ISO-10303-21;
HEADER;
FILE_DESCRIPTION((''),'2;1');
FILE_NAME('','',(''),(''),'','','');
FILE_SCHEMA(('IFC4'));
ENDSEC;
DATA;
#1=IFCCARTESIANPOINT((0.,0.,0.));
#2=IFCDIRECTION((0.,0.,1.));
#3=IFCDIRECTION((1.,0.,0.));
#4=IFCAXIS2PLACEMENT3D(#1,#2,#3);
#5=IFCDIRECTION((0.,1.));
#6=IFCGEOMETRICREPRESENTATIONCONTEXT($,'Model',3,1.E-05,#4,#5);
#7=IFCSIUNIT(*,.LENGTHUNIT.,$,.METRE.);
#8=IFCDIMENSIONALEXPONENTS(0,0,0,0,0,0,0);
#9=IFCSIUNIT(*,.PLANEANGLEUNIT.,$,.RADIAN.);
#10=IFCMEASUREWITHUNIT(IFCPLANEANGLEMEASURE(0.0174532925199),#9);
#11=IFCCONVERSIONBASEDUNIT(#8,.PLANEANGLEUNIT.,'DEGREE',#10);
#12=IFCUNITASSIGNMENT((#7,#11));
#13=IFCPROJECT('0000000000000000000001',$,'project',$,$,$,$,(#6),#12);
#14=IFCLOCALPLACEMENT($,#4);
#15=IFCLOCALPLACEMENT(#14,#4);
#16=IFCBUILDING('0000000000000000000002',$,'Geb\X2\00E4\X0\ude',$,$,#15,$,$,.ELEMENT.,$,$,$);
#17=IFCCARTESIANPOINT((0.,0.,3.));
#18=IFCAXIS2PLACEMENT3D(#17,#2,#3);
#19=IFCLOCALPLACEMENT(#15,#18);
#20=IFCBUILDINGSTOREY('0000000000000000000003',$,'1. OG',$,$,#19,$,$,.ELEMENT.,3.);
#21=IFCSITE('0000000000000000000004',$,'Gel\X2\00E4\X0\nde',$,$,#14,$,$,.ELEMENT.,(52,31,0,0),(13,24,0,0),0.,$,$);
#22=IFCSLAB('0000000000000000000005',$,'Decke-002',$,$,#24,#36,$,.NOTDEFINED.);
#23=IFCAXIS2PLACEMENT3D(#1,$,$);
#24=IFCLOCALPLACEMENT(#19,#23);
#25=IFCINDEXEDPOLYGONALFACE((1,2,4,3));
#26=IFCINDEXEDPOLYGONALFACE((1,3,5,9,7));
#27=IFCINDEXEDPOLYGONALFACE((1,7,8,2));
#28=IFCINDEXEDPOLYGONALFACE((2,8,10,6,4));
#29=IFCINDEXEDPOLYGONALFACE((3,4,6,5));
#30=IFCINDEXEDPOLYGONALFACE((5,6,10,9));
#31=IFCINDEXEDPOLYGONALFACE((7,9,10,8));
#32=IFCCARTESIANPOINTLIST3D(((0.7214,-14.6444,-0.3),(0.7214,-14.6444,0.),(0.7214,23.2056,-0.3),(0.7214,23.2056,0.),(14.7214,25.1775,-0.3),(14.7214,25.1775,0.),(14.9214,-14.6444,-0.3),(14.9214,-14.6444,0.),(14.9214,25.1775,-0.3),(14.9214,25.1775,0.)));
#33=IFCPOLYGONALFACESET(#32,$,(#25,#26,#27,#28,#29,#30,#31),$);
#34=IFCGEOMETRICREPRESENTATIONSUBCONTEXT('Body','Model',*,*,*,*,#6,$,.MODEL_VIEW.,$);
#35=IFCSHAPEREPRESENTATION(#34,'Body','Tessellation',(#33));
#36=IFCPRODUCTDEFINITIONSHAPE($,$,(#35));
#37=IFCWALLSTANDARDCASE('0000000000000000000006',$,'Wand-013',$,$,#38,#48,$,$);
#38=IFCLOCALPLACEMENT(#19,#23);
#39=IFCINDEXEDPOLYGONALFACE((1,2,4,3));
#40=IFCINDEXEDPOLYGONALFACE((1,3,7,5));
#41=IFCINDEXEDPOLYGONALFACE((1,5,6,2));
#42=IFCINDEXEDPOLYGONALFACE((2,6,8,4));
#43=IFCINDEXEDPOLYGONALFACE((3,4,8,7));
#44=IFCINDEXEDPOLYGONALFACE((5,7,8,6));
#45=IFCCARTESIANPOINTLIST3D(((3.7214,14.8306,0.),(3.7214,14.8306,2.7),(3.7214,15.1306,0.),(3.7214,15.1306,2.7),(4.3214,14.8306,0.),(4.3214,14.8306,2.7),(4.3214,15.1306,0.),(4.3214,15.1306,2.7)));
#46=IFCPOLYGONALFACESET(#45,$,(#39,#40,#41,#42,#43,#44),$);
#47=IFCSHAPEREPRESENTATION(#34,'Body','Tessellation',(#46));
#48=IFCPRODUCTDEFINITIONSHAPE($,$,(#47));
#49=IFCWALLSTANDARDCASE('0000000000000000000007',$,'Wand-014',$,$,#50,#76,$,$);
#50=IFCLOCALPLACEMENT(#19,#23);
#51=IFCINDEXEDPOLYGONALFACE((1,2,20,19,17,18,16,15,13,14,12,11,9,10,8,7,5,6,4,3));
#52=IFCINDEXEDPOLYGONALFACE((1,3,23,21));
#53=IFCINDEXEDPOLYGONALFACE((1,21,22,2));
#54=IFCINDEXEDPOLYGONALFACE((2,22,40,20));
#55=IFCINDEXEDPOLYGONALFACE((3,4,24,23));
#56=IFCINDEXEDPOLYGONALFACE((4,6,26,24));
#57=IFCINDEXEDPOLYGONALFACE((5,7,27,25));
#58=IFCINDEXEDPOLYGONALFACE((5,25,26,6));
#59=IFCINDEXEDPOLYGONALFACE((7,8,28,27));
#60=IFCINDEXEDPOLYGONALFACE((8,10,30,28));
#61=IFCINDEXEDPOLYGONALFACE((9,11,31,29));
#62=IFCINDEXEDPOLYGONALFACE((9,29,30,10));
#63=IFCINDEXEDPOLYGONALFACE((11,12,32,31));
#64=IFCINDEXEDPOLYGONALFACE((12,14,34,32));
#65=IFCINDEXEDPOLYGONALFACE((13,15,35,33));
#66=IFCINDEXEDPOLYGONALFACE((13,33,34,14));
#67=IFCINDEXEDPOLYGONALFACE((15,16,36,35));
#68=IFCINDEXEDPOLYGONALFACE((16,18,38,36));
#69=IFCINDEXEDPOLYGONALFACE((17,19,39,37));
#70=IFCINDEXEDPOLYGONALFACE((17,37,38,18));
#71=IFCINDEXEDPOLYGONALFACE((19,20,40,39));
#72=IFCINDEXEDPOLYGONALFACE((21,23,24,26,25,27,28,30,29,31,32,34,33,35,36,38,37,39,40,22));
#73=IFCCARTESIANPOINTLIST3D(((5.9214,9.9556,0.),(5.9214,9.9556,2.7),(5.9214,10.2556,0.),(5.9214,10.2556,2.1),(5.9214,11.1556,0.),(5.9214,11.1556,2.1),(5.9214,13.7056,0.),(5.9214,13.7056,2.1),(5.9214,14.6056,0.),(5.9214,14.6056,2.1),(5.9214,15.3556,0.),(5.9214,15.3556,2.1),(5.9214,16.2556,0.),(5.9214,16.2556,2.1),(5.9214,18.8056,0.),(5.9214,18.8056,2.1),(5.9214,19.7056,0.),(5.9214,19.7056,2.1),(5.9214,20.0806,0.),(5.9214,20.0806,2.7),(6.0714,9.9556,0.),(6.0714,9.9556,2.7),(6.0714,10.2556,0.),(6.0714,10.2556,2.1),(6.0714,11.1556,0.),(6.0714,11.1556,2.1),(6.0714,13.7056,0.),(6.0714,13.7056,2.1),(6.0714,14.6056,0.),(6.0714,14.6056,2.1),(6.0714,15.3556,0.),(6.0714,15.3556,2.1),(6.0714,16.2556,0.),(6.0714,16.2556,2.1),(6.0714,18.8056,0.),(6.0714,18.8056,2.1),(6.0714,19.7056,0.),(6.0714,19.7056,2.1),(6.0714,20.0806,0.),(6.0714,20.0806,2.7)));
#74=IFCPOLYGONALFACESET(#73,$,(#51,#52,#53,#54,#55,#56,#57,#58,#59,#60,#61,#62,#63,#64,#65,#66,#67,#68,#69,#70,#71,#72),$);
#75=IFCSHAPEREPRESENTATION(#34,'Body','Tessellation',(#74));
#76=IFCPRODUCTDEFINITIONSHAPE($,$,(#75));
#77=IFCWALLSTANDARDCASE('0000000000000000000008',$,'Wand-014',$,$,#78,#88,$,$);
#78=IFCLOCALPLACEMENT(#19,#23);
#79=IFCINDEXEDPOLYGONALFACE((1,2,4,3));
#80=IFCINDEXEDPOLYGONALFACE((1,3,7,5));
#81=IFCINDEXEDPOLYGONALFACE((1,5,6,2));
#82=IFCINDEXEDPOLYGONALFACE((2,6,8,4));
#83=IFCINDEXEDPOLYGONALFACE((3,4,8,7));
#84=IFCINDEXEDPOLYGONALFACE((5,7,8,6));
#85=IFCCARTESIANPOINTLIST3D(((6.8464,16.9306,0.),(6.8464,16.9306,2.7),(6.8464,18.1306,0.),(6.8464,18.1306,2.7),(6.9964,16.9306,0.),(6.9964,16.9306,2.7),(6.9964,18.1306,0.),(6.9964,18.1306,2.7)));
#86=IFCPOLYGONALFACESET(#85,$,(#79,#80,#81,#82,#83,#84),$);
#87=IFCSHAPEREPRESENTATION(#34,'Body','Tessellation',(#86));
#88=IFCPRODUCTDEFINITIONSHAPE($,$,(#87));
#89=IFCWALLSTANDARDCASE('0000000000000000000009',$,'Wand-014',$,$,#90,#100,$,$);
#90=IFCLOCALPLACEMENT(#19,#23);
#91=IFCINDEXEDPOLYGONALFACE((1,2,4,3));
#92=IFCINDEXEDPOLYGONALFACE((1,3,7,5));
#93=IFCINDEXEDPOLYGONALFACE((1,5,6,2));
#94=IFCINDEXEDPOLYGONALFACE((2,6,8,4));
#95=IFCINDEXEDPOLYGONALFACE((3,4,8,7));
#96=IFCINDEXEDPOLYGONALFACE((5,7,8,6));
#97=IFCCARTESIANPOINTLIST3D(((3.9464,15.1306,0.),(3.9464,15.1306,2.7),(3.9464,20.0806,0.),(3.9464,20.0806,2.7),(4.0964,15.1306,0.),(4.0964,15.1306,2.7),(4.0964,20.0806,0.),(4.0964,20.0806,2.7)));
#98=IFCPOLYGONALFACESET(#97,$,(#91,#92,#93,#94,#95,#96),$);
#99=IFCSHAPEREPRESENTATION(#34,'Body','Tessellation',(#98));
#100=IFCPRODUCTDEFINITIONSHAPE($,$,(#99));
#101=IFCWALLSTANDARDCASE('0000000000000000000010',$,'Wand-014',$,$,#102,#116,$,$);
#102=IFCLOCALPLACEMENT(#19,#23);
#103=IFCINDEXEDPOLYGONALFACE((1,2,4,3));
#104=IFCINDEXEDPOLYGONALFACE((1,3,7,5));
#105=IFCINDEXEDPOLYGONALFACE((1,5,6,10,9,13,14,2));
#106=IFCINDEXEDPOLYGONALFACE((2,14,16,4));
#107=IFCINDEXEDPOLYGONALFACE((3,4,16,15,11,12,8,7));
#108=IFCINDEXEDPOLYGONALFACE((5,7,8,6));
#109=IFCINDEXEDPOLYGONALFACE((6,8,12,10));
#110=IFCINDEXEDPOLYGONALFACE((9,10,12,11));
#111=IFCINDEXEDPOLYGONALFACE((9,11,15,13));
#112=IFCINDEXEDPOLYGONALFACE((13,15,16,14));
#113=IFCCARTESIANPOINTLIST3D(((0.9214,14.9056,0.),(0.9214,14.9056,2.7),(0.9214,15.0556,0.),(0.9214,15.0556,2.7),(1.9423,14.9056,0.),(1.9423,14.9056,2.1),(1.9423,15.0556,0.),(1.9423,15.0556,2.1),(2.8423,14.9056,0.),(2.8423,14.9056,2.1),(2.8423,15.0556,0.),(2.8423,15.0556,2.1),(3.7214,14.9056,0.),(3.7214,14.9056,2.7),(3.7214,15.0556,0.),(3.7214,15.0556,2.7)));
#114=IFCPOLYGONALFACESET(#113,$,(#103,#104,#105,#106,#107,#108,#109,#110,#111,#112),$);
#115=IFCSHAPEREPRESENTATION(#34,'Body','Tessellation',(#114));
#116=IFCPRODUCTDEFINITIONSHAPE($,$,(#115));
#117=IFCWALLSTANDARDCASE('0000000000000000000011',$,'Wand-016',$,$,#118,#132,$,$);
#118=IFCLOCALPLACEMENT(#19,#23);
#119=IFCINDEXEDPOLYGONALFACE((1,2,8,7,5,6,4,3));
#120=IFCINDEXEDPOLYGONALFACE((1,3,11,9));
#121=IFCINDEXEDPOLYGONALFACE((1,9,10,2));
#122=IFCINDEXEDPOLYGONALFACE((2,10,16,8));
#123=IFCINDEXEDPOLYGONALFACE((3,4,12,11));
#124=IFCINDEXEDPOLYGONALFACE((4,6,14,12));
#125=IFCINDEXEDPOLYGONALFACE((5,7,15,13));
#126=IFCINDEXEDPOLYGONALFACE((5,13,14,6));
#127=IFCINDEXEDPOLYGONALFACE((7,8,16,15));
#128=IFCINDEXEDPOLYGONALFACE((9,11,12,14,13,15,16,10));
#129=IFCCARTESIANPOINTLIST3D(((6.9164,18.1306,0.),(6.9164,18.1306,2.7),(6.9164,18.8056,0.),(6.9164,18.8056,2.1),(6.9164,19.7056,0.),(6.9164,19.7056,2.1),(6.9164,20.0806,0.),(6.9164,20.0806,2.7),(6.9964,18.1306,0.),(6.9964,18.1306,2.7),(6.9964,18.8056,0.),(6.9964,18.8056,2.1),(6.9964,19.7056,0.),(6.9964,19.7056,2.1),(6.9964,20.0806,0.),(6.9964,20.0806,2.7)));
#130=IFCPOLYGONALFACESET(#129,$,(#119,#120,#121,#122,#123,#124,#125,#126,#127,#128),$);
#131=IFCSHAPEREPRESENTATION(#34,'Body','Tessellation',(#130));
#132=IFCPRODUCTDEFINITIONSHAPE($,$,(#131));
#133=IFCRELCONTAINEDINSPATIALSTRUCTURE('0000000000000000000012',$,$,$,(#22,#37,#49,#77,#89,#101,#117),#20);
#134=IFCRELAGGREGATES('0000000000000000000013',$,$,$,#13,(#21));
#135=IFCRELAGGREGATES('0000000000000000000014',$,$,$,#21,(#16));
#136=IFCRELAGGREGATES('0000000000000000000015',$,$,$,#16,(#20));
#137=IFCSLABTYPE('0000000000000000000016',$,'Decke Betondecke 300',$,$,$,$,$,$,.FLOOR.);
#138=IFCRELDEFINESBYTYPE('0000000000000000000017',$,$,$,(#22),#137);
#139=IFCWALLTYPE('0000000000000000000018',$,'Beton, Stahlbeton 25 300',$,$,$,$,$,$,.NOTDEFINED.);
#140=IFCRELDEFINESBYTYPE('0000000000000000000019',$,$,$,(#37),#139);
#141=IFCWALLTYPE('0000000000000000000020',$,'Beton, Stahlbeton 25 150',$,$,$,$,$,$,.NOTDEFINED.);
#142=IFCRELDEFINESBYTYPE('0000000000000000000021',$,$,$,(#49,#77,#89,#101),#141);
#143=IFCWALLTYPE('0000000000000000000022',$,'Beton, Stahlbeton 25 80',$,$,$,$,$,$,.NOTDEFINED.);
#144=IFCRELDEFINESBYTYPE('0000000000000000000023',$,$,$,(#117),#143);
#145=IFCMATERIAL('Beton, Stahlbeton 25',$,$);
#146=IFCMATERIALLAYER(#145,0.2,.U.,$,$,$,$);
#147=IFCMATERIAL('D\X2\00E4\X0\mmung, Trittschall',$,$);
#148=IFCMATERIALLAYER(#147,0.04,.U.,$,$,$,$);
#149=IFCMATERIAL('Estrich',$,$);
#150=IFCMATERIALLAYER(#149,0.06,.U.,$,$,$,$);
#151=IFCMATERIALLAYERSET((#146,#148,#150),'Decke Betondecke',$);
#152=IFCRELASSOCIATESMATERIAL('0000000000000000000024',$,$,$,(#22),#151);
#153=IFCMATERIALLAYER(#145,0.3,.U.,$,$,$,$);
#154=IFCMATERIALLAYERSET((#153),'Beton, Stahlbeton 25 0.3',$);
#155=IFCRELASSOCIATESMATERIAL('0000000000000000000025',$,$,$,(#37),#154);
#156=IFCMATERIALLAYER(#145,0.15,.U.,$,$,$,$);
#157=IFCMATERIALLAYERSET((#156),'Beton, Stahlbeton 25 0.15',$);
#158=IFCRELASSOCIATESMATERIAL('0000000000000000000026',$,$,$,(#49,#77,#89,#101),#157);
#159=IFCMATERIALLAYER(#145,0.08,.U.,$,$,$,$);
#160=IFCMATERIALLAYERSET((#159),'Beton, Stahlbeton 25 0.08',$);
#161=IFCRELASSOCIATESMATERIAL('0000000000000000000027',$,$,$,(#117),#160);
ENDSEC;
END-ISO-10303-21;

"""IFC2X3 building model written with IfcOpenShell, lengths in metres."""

from ifc_helpers import new_model, entity, si_unit, converted_unit, direction, frame, origin_with_axes, origin_2d_with_axis, place, context, subcontext, project, spatial, polyline, rectangle, outline, extrude, material, layer, layer_set, layer_usage, type_object, element, save


model = new_model("IFC2X3")

# Units and contexts
model_context = context("Model", 3, precision=1e-05, world=origin_with_axes(), true_north=direction((0.0, 1.0)))
body_context = subcontext(model_context, "Body", "Model", "MODEL_VIEW")
ifc_project = project(units=[si_unit("LENGTHUNIT", "METRE"), converted_unit("PLANEANGLEUNIT", "DEGREE", entity("IfcPlaneAngleMeasure", 0.0174532925199), si_unit("PLANEANGLEUNIT", "RADIAN"), dimensions=[0, 0, 0, 0, 0, 0, 0])], contexts=[model_context])

# Site, building, storey
site_placement = place(None, origin_with_axes())
site = spatial("IfcSite", under=ifc_project, at=site_placement, Name="Gelände", CompositionType="ELEMENT", RefLatitude=(52, 31, 0, 0), RefLongitude=(13, 24, 0, 0), RefElevation=0.0)
building_placement = place(site_placement, origin_with_axes())
building = spatial("IfcBuilding", under=site, at=building_placement, Name="Gebäude", CompositionType="ELEMENT")
storey_placement = place(building_placement, frame((0.0, 0.0, 3.0), z_axis=(0.0, 0.0, 1.0), x_axis=(1.0, 0.0, 0.0)))
storey = spatial("IfcBuildingStorey", under=building, at=storey_placement, Name="1. OG", CompositionType="ELEMENT", Elevation=3.0)

# Slab
ifc_material_1 = material(Name="Beton, Stahlbeton 25")
ifc_layer_1 = layer(ifc_material_1, 0.2, ventilated="UNKNOWN")
ifc_material_2 = material(Name="Dämmung, Trittschall")
ifc_layer_2 = layer(ifc_material_2, 0.04, ventilated="UNKNOWN")
ifc_material_3 = material(Name="Estrich")
ifc_layer_3 = layer(ifc_material_3, 0.06, ventilated="UNKNOWN")
ifc_layer_set_1 = layer_set([ifc_layer_1, ifc_layer_2, ifc_layer_3], Name="Decke Betondecke")
ifc_layer_usage_1 = layer_usage(ifc_layer_set_1, "AXIS3", "NEGATIVE", 0.3)
slab_type = type_object("IfcSlabType", Name="Decke Betondecke 300", PredefinedType="FLOOR")
slab_placement = place(storey_placement, frame((0.7214, 23.2056, 0.0), z_axis=(0.0, 0.0, 1.0), x_axis=(1.0, 0.0, 0.0)))
element("IfcSlab", 1, at=slab_placement, inside=storey, type_object=slab_type, material=ifc_layer_usage_1, Name="Decke-002", PredefinedType="NOTDEFINED", context=body_context, shape_type="SweptSolid", body=[
    extrude(outline(polyline([(0.0, 0.0), (0.0, -37.85), (14.2, -37.85), (14.2, 1.9718), (14.0, 1.9718), (0.0, 0.0)])), frame((0.0, 0.0, -0.3), z_axis=(0.0, 0.0, 1.0), x_axis=(1.0, 0.0, 0.0)), (0.0, 0.0, 1.0), 0.3),
])

# Wall
ifc_layer_4 = layer(ifc_material_1, 0.3, ventilated="UNKNOWN")
ifc_layer_set_2 = layer_set([ifc_layer_4], Name="Beton, Stahlbeton 25 0.3")
ifc_layer_usage_2 = layer_usage(ifc_layer_set_2, "AXIS2", "NEGATIVE", 0.3)
wall_type_1 = type_object("IfcWallType", Name="Beton, Stahlbeton 25 300", PredefinedType="NOTDEFINED")
wall_1_placement = place(storey_placement, frame((3.7214, 14.8306, 0.0), z_axis=(0.0, 0.0, 1.0), x_axis=(1.0, 0.0, 0.0)))
element("IfcWallStandardCase", 2, at=wall_1_placement, inside=storey, type_object=wall_type_1, material=ifc_layer_usage_2, Name="Wand-013", context=body_context, shape_type="SweptSolid", body=[
    extrude(outline(polyline([(0.0, 0.0), (0.6, 0.0), (0.6, 0.3), (0.0, 0.3), (0.0, 0.0)])), origin_with_axes(), (0.0, 0.0, 1.0), 2.7),
])

# Wall, openings
ifc_layer_5 = layer(ifc_material_1, 0.15, ventilated="UNKNOWN")
ifc_layer_set_3 = layer_set([ifc_layer_5], Name="Beton, Stahlbeton 25 0.15")
ifc_layer_usage_3 = layer_usage(ifc_layer_set_3, "AXIS2", "POSITIVE", 0.0)
wall_type_2 = type_object("IfcWallType", Name="Beton, Stahlbeton 25 150", PredefinedType="NOTDEFINED")
wall_2_placement = place(storey_placement, frame((5.9214, 20.0806, 0.0), z_axis=(0.0, 0.0, 1.0), x_axis=(0.0, -1.0, 0.0)))
wall_2 = element("IfcWallStandardCase", 3, at=wall_2_placement, inside=storey, type_object=wall_type_2, material=ifc_layer_usage_3, Name="Wand-014", context=body_context, shape_type="SweptSolid", body=[
    extrude(outline(polyline([(0.0, 0.0), (10.125, 0.0), (10.125, 0.15), (0.0, 0.15), (0.0, 0.0)])), origin_with_axes(), (0.0, 0.0, 1.0), 2.7),
])
opening_1_placement = place(wall_2_placement, frame((4.275, 0.0, 0.0), z_axis=(0.0, 0.0, 1.0), x_axis=(1.0, 0.0, 0.0)))
element("IfcOpeningElement", 4, at=opening_1_placement, cuts=wall_2, context=body_context, shape_type="SweptSolid", body=[
    extrude(rectangle(XDim=0.9, YDim=2.1, at=origin_2d_with_axis()), frame((0.0, 0.3, 1.05), z_axis=(0.0, -1.0, 0.0), x_axis=(1.0, 0.0, 0.0)), (0.0, 0.0, 1.0), 0.15),
    extrude(rectangle(XDim=0.9, YDim=2.1, at=origin_2d_with_axis()), frame((0.0, 0.0, 1.05), z_axis=(0.0, 1.0, 0.0), x_axis=(1.0, 0.0, 0.0)), (0.0, 0.0, 1.0), 0.15),
])
opening_2_placement = place(wall_2_placement, frame((5.925, 0.0, 0.0), z_axis=(0.0, 0.0, 1.0), x_axis=(1.0, 0.0, 0.0)))
element("IfcOpeningElement", 5, at=opening_2_placement, cuts=wall_2, context=body_context, shape_type="SweptSolid", body=[
    extrude(rectangle(XDim=0.9, YDim=2.1, at=origin_2d_with_axis()), frame((0.0, 0.3, 1.05), z_axis=(0.0, -1.0, 0.0), x_axis=(1.0, 0.0, 0.0)), (0.0, 0.0, 1.0), 0.15),
    extrude(rectangle(XDim=0.9, YDim=2.1, at=origin_2d_with_axis()), frame((0.0, 0.0, 1.05), z_axis=(0.0, 1.0, 0.0), x_axis=(1.0, 0.0, 0.0)), (0.0, 0.0, 1.0), 0.15),
])
opening_3_placement = place(wall_2_placement, frame((9.375, 0.0, 0.0), z_axis=(0.0, 0.0, 1.0), x_axis=(1.0, 0.0, 0.0)))
element("IfcOpeningElement", 6, at=opening_3_placement, cuts=wall_2, context=body_context, shape_type="SweptSolid", body=[
    extrude(rectangle(XDim=0.9, YDim=2.1, at=origin_2d_with_axis()), frame((0.0, 0.3, 1.05), z_axis=(0.0, -1.0, 0.0), x_axis=(1.0, 0.0, 0.0)), (0.0, 0.0, 1.0), 0.15),
    extrude(rectangle(XDim=0.9, YDim=2.1, at=origin_2d_with_axis()), frame((0.0, 0.0, 1.05), z_axis=(0.0, 1.0, 0.0), x_axis=(1.0, 0.0, 0.0)), (0.0, 0.0, 1.0), 0.15),
])
opening_4_placement = place(wall_2_placement, frame((0.825, 0.0, 0.0), z_axis=(0.0, 0.0, 1.0), x_axis=(1.0, 0.0, 0.0)))
element("IfcOpeningElement", 7, at=opening_4_placement, cuts=wall_2, context=body_context, shape_type="SweptSolid", body=[
    extrude(rectangle(XDim=0.9, YDim=2.1, at=origin_2d_with_axis()), frame((0.0, 0.3, 1.05), z_axis=(0.0, -1.0, 0.0), x_axis=(1.0, 0.0, 0.0)), (0.0, 0.0, 1.0), 0.15),
    extrude(rectangle(XDim=0.9, YDim=2.1, at=origin_2d_with_axis()), frame((0.0, 0.0, 1.05), z_axis=(0.0, 1.0, 0.0), x_axis=(1.0, 0.0, 0.0)), (0.0, 0.0, 1.0), 0.15),
])

# Walls
ifc_layer_usage_4 = layer_usage(ifc_layer_set_3, "AXIS2", "POSITIVE", 0.0)
wall_3_placement = place(storey_placement, frame((6.9964, 16.9306, 0.0), z_axis=(0.0, 0.0, 1.0), x_axis=(0.0, 1.0, 0.0)))
element("IfcWallStandardCase", 8, at=wall_3_placement, inside=storey, type_object=wall_type_2, material=ifc_layer_usage_4, Name="Wand-014", context=body_context, shape_type="SweptSolid", body=[
    extrude(outline(polyline([(0.0, 0.0), (1.2, 0.0), (1.2, 0.15), (0.0, 0.15), (0.0, 0.0)])), origin_with_axes(), (0.0, 0.0, 1.0), 2.7),
])
ifc_layer_usage_5 = layer_usage(ifc_layer_set_3, "AXIS2", "NEGATIVE", 0.075)
wall_4_placement = place(storey_placement, frame((4.0214, 15.1306, 0.0), z_axis=(0.0, 0.0, 1.0), x_axis=(0.0, 1.0, 0.0)))
element("IfcWallStandardCase", 9, at=wall_4_placement, inside=storey, type_object=wall_type_2, material=ifc_layer_usage_5, Name="Wand-014", context=body_context, shape_type="SweptSolid", body=[
    extrude(outline(polyline([(0.0, -0.075), (4.95, -0.075), (4.95, 0.075), (0.0, 0.075), (0.0, -0.075)])), origin_with_axes(), (0.0, 0.0, 1.0), 2.7),
])

# Walls, openings
ifc_layer_usage_6 = layer_usage(ifc_layer_set_3, "AXIS2", "NEGATIVE", 0.075)
wall_5_placement = place(storey_placement, frame((3.7214, 14.9806, 0.0), z_axis=(0.0, 0.0, 1.0), x_axis=(-1.0, 0.0, 0.0)))
wall_5 = element("IfcWallStandardCase", 10, at=wall_5_placement, inside=storey, type_object=wall_type_2, material=ifc_layer_usage_6, Name="Wand-014", context=body_context, shape_type="SweptSolid", body=[
    extrude(outline(polyline([(0.0, -0.075), (2.8, -0.075), (2.8, 0.075), (0.0, 0.075), (0.0, -0.075)])), origin_with_axes(), (0.0, 0.0, 1.0), 2.7),
])
opening_5_placement = place(wall_5_placement, frame((1.3292, 0.0, 0.0), z_axis=(0.0, 0.0, 1.0), x_axis=(1.0, 0.0, 0.0)))
element("IfcOpeningElement", 11, at=opening_5_placement, cuts=wall_5, context=body_context, shape_type="SweptSolid", body=[
    extrude(rectangle(XDim=0.9, YDim=2.1, at=origin_2d_with_axis()), frame((0.0, -0.225, 1.05), z_axis=(0.0, 1.0, 0.0), x_axis=(1.0, 0.0, 0.0)), (0.0, 0.0, 1.0), 0.15),
    extrude(rectangle(XDim=0.9, YDim=2.1, at=origin_2d_with_axis()), frame((0.0, 0.075, 1.05), z_axis=(0.0, -1.0, 0.0), x_axis=(1.0, 0.0, 0.0)), (0.0, 0.0, 1.0), 0.15),
])
ifc_layer_6 = layer(ifc_material_1, 0.08, ventilated="UNKNOWN")
ifc_layer_set_4 = layer_set([ifc_layer_6], Name="Beton, Stahlbeton 25 0.08")
ifc_layer_usage_7 = layer_usage(ifc_layer_set_4, "AXIS2", "NEGATIVE", 0.0)
wall_type_3 = type_object("IfcWallType", Name="Beton, Stahlbeton 25 80", PredefinedType="NOTDEFINED")
wall_6_placement = place(storey_placement, frame((6.9164, 18.1306, 0.0), z_axis=(0.0, 0.0, 1.0), x_axis=(0.0, 1.0, 0.0)))
wall_6 = element("IfcWallStandardCase", 12, at=wall_6_placement, inside=storey, type_object=wall_type_3, material=ifc_layer_usage_7, Name="Wand-016", context=body_context, shape_type="SweptSolid", body=[
    extrude(outline(polyline([(0.0, -0.08), (1.95, -0.08), (1.95, 0.0), (0.0, 0.0), (0.0, -0.08)])), origin_with_axes(), (0.0, 0.0, 1.0), 2.7),
])
opening_6_placement = place(wall_6_placement, frame((1.125, 0.0, 0.0), z_axis=(0.0, 0.0, 1.0), x_axis=(1.0, 0.0, 0.0)))
element("IfcOpeningElement", 13, at=opening_6_placement, cuts=wall_6, context=body_context, shape_type="SweptSolid", body=[
    extrude(rectangle(XDim=0.9, YDim=2.1, at=origin_2d_with_axis()), frame((0.0, 0.08, 1.05), z_axis=(0.0, -1.0, 0.0), x_axis=(1.0, 0.0, 0.0)), (0.0, 0.0, 1.0), 0.08),
    extrude(rectangle(XDim=0.9, YDim=2.1, at=origin_2d_with_axis()), frame((0.0, -0.08, 1.05), z_axis=(0.0, 1.0, 0.0), x_axis=(1.0, 0.0, 0.0)), (0.0, 0.0, 1.0), 0.08),
])

save(model, "model.ifc")
